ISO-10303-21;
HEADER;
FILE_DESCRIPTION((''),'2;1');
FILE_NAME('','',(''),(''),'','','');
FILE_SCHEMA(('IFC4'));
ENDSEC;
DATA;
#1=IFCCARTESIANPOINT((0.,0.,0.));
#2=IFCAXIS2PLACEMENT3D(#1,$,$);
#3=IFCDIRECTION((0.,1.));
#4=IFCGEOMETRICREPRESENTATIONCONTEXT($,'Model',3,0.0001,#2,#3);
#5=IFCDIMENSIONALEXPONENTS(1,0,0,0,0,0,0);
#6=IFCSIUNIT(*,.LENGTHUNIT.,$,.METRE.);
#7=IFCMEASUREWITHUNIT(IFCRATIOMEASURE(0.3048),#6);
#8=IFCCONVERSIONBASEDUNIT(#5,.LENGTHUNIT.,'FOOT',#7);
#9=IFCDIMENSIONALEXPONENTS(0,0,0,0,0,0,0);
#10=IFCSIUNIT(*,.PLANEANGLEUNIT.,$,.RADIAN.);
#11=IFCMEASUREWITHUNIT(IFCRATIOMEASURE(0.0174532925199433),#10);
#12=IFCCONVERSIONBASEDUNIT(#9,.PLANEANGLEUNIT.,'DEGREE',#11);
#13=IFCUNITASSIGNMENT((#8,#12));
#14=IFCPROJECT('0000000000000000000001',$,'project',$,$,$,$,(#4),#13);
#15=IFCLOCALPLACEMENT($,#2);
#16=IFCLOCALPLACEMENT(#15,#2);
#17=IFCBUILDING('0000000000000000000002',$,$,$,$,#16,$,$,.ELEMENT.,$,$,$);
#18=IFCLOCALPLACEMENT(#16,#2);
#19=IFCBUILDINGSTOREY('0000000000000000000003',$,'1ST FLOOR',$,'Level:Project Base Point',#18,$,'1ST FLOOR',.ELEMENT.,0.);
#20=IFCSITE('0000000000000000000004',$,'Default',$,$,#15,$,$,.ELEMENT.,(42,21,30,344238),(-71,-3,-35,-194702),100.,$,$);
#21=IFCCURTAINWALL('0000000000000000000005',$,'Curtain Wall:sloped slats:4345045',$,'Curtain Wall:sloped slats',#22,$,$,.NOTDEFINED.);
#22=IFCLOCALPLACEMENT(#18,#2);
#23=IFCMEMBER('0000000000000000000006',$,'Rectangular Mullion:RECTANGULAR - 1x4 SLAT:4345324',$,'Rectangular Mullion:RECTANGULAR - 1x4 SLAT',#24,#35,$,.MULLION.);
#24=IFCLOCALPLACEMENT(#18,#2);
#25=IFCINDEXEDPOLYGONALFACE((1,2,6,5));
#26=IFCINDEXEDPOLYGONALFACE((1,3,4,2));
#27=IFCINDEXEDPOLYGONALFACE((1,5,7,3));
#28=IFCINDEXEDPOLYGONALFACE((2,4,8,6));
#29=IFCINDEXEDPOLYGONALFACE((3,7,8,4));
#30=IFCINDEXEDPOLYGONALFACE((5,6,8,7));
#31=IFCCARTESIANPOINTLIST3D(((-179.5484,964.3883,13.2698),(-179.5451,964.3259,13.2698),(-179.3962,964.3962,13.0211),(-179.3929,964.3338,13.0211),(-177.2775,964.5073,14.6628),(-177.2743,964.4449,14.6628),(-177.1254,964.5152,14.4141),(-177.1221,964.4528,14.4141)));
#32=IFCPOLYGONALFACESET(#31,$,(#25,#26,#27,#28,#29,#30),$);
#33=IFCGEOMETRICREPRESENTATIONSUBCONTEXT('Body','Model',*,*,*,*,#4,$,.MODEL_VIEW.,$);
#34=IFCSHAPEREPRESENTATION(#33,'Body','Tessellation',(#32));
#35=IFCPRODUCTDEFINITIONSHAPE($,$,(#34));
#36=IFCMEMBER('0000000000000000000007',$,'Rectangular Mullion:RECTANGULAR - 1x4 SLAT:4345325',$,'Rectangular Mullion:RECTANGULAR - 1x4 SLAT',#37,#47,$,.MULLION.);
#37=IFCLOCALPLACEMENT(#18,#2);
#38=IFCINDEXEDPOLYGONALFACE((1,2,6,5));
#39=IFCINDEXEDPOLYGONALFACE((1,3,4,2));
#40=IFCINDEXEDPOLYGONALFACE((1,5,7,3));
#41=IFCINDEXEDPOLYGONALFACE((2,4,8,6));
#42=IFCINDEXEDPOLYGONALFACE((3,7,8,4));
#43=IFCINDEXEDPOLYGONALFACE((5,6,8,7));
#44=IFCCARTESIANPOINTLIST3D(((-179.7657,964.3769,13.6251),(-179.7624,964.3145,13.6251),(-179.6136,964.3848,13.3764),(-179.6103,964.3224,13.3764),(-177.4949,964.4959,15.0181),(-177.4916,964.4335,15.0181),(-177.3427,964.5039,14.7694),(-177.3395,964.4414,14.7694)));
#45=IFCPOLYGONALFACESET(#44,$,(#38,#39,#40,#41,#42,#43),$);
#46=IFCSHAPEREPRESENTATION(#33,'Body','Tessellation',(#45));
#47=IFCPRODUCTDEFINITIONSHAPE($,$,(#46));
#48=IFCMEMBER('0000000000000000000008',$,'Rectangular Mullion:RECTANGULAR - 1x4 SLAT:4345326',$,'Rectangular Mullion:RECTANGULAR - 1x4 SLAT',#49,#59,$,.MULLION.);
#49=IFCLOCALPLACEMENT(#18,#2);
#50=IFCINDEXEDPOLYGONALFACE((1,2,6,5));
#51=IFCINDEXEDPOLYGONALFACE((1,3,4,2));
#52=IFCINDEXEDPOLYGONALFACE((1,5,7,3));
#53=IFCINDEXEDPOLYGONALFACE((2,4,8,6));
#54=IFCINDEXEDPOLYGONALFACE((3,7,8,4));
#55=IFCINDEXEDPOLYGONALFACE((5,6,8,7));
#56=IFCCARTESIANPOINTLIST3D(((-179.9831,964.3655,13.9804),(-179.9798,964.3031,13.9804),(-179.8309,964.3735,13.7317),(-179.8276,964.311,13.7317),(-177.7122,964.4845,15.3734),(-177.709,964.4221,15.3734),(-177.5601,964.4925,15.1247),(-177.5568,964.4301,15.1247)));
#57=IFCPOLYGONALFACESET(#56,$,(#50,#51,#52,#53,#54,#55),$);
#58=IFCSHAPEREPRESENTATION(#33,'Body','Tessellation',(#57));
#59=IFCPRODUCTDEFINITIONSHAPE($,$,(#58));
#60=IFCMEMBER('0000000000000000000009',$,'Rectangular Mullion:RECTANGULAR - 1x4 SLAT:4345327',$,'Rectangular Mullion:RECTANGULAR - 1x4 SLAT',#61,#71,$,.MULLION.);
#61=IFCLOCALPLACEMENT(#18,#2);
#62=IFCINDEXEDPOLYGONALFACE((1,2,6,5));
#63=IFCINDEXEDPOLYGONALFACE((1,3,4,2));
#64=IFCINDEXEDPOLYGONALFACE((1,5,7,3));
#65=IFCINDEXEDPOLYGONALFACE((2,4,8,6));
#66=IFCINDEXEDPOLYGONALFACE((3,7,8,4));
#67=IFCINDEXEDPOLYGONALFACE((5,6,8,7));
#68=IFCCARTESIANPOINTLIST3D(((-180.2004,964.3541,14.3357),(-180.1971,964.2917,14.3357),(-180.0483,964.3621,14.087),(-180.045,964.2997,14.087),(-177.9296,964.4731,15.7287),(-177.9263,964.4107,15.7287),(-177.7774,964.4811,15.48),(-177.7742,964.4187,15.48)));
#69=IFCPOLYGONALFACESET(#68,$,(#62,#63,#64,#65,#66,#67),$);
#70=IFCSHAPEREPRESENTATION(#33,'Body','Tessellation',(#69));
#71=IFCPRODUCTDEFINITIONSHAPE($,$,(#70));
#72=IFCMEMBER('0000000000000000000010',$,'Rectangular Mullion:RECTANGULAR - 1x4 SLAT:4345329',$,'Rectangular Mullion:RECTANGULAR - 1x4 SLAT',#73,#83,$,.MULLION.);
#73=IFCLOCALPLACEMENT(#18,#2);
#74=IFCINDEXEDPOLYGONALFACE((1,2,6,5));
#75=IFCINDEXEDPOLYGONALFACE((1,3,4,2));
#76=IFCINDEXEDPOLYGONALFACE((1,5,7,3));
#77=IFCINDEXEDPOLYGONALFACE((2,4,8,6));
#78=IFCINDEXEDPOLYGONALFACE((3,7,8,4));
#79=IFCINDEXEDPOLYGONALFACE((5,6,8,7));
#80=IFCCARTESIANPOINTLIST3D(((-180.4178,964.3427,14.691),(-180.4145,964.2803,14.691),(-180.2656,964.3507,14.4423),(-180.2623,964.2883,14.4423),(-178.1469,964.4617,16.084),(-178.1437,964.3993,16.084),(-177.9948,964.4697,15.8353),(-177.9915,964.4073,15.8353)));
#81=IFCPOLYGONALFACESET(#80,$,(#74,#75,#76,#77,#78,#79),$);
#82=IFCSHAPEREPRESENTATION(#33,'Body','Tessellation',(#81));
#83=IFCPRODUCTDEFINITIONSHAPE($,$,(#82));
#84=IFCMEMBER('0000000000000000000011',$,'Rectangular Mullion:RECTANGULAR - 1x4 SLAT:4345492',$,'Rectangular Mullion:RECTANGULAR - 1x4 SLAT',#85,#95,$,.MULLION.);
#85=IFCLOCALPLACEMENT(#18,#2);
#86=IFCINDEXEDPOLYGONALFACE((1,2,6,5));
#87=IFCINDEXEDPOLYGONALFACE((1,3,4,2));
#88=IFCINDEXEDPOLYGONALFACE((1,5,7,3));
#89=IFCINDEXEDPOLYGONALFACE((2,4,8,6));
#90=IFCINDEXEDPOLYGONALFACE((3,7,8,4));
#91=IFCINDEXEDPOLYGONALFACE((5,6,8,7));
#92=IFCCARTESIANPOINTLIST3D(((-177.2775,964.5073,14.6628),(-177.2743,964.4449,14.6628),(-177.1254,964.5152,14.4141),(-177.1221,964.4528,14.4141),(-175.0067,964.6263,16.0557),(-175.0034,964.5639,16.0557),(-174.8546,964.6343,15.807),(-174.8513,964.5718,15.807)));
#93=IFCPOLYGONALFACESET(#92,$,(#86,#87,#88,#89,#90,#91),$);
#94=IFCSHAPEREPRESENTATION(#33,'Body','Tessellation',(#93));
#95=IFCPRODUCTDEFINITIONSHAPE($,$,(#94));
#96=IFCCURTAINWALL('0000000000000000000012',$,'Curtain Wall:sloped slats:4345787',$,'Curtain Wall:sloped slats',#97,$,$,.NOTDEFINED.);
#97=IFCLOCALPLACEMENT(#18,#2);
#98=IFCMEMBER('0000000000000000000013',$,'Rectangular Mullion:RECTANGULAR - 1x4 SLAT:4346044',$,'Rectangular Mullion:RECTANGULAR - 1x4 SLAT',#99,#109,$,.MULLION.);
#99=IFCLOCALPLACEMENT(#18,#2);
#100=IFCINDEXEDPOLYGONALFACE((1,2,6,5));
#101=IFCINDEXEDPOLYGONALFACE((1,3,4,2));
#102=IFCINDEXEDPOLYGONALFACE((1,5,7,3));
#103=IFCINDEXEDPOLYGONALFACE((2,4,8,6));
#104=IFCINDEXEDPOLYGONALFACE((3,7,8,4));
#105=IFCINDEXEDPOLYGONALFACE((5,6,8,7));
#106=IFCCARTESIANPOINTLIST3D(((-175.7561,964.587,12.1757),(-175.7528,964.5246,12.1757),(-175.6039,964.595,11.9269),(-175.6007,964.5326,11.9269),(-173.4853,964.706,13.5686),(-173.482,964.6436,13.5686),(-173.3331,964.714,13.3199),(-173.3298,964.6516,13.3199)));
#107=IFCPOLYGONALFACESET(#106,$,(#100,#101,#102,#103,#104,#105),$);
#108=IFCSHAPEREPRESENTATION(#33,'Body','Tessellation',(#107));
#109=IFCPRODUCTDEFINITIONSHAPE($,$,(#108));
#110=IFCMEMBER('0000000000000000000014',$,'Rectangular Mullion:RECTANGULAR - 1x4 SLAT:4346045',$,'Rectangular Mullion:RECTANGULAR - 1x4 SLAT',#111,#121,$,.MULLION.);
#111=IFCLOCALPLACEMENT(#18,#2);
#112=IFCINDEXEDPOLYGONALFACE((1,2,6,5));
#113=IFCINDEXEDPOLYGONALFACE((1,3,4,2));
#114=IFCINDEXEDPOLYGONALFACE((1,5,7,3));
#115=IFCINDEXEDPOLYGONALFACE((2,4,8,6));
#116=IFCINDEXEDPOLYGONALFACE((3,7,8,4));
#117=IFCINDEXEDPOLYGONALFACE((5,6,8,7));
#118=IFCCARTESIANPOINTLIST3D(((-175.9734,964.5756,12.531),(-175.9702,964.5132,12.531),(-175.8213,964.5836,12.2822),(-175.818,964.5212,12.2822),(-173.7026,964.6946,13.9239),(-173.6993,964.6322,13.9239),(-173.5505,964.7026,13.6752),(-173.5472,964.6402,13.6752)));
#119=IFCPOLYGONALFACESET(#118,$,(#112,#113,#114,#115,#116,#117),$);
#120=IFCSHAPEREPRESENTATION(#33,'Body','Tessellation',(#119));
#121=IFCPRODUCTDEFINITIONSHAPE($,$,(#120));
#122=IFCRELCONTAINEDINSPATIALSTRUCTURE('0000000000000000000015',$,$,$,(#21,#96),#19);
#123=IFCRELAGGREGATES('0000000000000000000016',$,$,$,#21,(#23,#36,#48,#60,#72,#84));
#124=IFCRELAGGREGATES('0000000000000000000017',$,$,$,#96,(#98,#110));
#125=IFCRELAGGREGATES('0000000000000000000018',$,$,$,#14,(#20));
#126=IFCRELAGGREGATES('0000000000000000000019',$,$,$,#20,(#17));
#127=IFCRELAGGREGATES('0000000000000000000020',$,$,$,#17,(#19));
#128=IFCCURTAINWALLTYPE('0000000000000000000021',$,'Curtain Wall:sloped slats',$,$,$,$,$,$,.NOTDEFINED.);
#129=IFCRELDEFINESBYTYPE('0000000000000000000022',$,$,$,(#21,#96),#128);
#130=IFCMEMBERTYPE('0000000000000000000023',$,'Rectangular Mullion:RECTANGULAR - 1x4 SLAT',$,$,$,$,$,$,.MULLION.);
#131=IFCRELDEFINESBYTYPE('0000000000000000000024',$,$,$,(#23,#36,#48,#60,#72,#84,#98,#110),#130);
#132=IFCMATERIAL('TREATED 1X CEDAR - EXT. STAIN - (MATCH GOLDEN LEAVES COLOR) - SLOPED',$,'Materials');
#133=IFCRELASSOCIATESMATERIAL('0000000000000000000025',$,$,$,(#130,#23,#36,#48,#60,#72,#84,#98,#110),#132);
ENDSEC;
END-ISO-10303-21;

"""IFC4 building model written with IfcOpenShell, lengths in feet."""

from ifc_helpers import new_model, entity, si_unit, converted_unit, direction, frame, frame_2d, origin, place, context, subcontext, project, spatial, rectangle, extrude, source, transform, mapped, material, material_profile, profile_set, profile_usage, type_object, type_shapes, element, aggregate, save


model = new_model("IFC4")

# Units and contexts
model_context = context("Model", 3, precision=0.0001, world=origin(), true_north=direction((0.0, 1.0)))
body_context = subcontext(model_context, "Body", "Model", "MODEL_VIEW")
ifc_project = project(units=[converted_unit("LENGTHUNIT", "FOOT", entity("IfcRatioMeasure", 0.3048), si_unit("LENGTHUNIT", "METRE"), dimensions=[1, 0, 0, 0, 0, 0, 0]), converted_unit("PLANEANGLEUNIT", "DEGREE", entity("IfcRatioMeasure", 0.0174532925199433), si_unit("PLANEANGLEUNIT", "RADIAN"), dimensions=[0, 0, 0, 0, 0, 0, 0])], contexts=[model_context])

# Site, building, storey
site_placement = place(None, origin())
site = spatial("IfcSite", under=ifc_project, at=site_placement, Name="Default", CompositionType="ELEMENT", RefLatitude=(42, 21, 30, 344238), RefLongitude=(-71, -3, -35, -194702), RefElevation=100.0)
building_placement = place(site_placement, origin())
building = spatial("IfcBuilding", under=site, at=building_placement, CompositionType="ELEMENT")
storey_placement = place(building_placement, origin())
storey = spatial("IfcBuildingStorey", under=building, at=storey_placement, Name="1ST FLOOR", ObjectType="Level:Project Base Point", LongName="1ST FLOOR", CompositionType="ELEMENT", Elevation=0.0)

# Curtain walls, members
curtain_wall_type_1 = type_object("IfcCurtainWallType", Name="Curtain Wall:sloped slats", PredefinedType="NOTDEFINED")
curtain_wall_1_placement = place(storey_placement, origin())
curtain_wall_1 = element("IfcCurtainWall", 1, at=curtain_wall_1_placement, inside=storey, type_object=curtain_wall_type_1, Name="Curtain Wall:sloped slats:4345045", ObjectType="Curtain Wall:sloped slats", PredefinedType="NOTDEFINED")
ifc_material_1 = material(Name="TREATED 1X CEDAR - EXT. STAIN - (MATCH GOLDEN LEAVES COLOR) - SLOPED", Category="Materials")
ifc_material_profile_1 = material_profile(ifc_material_1, rectangle(XDim=0.0625, YDim=0.2917, at=frame_2d((0.0, 0.0), x_axis=(1.0, 0.0))), Name="RECTANGULAR - 1x4 SLAT")
ifc_profile_set_1 = profile_set([ifc_material_profile_1], Name="RECTANGULAR - 1x4 SLAT")
ifc_profile_usage_1 = profile_usage(ifc_profile_set_1)
member_type_1 = type_object("IfcMemberType", Name="Rectangular Mullion:RECTANGULAR - 1x4 SLAT", PredefinedType="MULLION", material=ifc_profile_set_1)
shared_shape_1 = source(origin(), body_context, "Body", "SweptSolid", [
    extrude(rectangle(XDim=0.0625, YDim=0.2917, at=frame_2d((0.0, 0.0), x_axis=(1.0, 0.0))), frame((0.0, 0.0, -2.6667), z_axis=(0.0, 0.0, 1.0), x_axis=(0.0, -1.0, 0.0)), (0.0, 0.0, 1.0), 2.6667),
])
type_shapes(member_type_1, [shared_shape_1])
member_1_placement = place(storey_placement, frame((-179.4707, 964.361, 13.1455), z_axis=(-0.851559, -0.044628, -0.522356), x_axis=(-0.52164, -0.027338, 0.852727)))
member_1 = element("IfcMember", 2, at=member_1_placement, type_object=member_type_1, material=ifc_profile_usage_1, Name="Rectangular Mullion:RECTANGULAR - 1x4 SLAT:4345324", ObjectType="Rectangular Mullion:RECTANGULAR - 1x4 SLAT", PredefinedType="MULLION", context=body_context, shape_type="MappedRepresentation", body=[
    mapped(shared_shape_1, transform((0.0, 0.0, 0.0), scale=1.0)),
])
ifc_profile_usage_2 = profile_usage(ifc_profile_set_1)
member_2_placement = place(storey_placement, frame((-179.688, 964.3497, 13.5008), z_axis=(-0.851559, -0.044628, -0.522356), x_axis=(-0.52164, -0.027338, 0.852727)))
member_2 = element("IfcMember", 3, at=member_2_placement, type_object=member_type_1, material=ifc_profile_usage_2, Name="Rectangular Mullion:RECTANGULAR - 1x4 SLAT:4345325", ObjectType="Rectangular Mullion:RECTANGULAR - 1x4 SLAT", PredefinedType="MULLION", context=body_context, shape_type="MappedRepresentation", body=[
    mapped(shared_shape_1, transform((0.0, 0.0, 0.0), scale=1.0)),
])
ifc_profile_usage_3 = profile_usage(ifc_profile_set_1)
member_3_placement = place(storey_placement, frame((-179.9054, 964.3383, 13.8561), z_axis=(-0.851559, -0.044628, -0.522356), x_axis=(-0.52164, -0.027338, 0.852727)))
member_3 = element("IfcMember", 4, at=member_3_placement, type_object=member_type_1, material=ifc_profile_usage_3, Name="Rectangular Mullion:RECTANGULAR - 1x4 SLAT:4345326", ObjectType="Rectangular Mullion:RECTANGULAR - 1x4 SLAT", PredefinedType="MULLION", context=body_context, shape_type="MappedRepresentation", body=[
    mapped(shared_shape_1, transform((0.0, 0.0, 0.0), scale=1.0)),
])
ifc_profile_usage_4 = profile_usage(ifc_profile_set_1)
member_4_placement = place(storey_placement, frame((-180.1227, 964.3269, 14.2114), z_axis=(-0.851559, -0.044628, -0.522356), x_axis=(-0.52164, -0.027338, 0.852727)))
member_4 = element("IfcMember", 5, at=member_4_placement, type_object=member_type_1, material=ifc_profile_usage_4, Name="Rectangular Mullion:RECTANGULAR - 1x4 SLAT:4345327", ObjectType="Rectangular Mullion:RECTANGULAR - 1x4 SLAT", PredefinedType="MULLION", context=body_context, shape_type="MappedRepresentation", body=[
    mapped(shared_shape_1, transform((0.0, 0.0, 0.0), scale=1.0)),
])
ifc_profile_usage_5 = profile_usage(ifc_profile_set_1)
member_5_placement = place(storey_placement, frame((-180.3401, 964.3155, 14.5667), z_axis=(-0.851559, -0.044628, -0.522356), x_axis=(-0.52164, -0.027338, 0.852727)))
member_5 = element("IfcMember", 6, at=member_5_placement, type_object=member_type_1, material=ifc_profile_usage_5, Name="Rectangular Mullion:RECTANGULAR - 1x4 SLAT:4345329", ObjectType="Rectangular Mullion:RECTANGULAR - 1x4 SLAT", PredefinedType="MULLION", context=body_context, shape_type="MappedRepresentation", body=[
    mapped(shared_shape_1, transform((0.0, 0.0, 0.0), scale=1.0)),
])
ifc_profile_usage_6 = profile_usage(ifc_profile_set_1)
member_6_placement = place(storey_placement, frame((-177.1998, 964.4801, 14.5384), z_axis=(-0.851559, -0.044628, -0.522356), x_axis=(-0.52164, -0.027338, 0.852727)))
member_6 = element("IfcMember", 7, at=member_6_placement, type_object=member_type_1, material=ifc_profile_usage_6, Name="Rectangular Mullion:RECTANGULAR - 1x4 SLAT:4345492", ObjectType="Rectangular Mullion:RECTANGULAR - 1x4 SLAT", PredefinedType="MULLION", context=body_context, shape_type="MappedRepresentation", body=[
    mapped(shared_shape_1, transform((0.0, 0.0, 0.0), scale=1.0)),
])
aggregate(curtain_wall_1, [member_1, member_2, member_3, member_4, member_5, member_6])
curtain_wall_2_placement = place(storey_placement, origin())
curtain_wall_2 = element("IfcCurtainWall", 8, at=curtain_wall_2_placement, inside=storey, type_object=curtain_wall_type_1, Name="Curtain Wall:sloped slats:4345787", ObjectType="Curtain Wall:sloped slats", PredefinedType="NOTDEFINED")
ifc_profile_usage_7 = profile_usage(ifc_profile_set_1)
member_7_placement = place(storey_placement, frame((-175.6784, 964.5598, 12.0513), z_axis=(-0.851559, -0.044628, -0.522356), x_axis=(-0.52164, -0.027338, 0.852727)))
member_7 = element("IfcMember", 9, at=member_7_placement, type_object=member_type_1, material=ifc_profile_usage_7, Name="Rectangular Mullion:RECTANGULAR - 1x4 SLAT:4346044", ObjectType="Rectangular Mullion:RECTANGULAR - 1x4 SLAT", PredefinedType="MULLION", context=body_context, shape_type="MappedRepresentation", body=[
    mapped(shared_shape_1, transform((0.0, 0.0, 0.0), scale=1.0)),
])
ifc_profile_usage_8 = profile_usage(ifc_profile_set_1)
member_8_placement = place(storey_placement, frame((-175.8957, 964.5484, 12.4066), z_axis=(-0.851559, -0.044628, -0.522356), x_axis=(-0.52164, -0.027338, 0.852727)))
member_8 = element("IfcMember", 10, at=member_8_placement, type_object=member_type_1, material=ifc_profile_usage_8, Name="Rectangular Mullion:RECTANGULAR - 1x4 SLAT:4346045", ObjectType="Rectangular Mullion:RECTANGULAR - 1x4 SLAT", PredefinedType="MULLION", context=body_context, shape_type="MappedRepresentation", body=[
    mapped(shared_shape_1, transform((0.0, 0.0, 0.0), scale=1.0)),
])
aggregate(curtain_wall_2, [member_7, member_8])

save(model, "model.ifc")
